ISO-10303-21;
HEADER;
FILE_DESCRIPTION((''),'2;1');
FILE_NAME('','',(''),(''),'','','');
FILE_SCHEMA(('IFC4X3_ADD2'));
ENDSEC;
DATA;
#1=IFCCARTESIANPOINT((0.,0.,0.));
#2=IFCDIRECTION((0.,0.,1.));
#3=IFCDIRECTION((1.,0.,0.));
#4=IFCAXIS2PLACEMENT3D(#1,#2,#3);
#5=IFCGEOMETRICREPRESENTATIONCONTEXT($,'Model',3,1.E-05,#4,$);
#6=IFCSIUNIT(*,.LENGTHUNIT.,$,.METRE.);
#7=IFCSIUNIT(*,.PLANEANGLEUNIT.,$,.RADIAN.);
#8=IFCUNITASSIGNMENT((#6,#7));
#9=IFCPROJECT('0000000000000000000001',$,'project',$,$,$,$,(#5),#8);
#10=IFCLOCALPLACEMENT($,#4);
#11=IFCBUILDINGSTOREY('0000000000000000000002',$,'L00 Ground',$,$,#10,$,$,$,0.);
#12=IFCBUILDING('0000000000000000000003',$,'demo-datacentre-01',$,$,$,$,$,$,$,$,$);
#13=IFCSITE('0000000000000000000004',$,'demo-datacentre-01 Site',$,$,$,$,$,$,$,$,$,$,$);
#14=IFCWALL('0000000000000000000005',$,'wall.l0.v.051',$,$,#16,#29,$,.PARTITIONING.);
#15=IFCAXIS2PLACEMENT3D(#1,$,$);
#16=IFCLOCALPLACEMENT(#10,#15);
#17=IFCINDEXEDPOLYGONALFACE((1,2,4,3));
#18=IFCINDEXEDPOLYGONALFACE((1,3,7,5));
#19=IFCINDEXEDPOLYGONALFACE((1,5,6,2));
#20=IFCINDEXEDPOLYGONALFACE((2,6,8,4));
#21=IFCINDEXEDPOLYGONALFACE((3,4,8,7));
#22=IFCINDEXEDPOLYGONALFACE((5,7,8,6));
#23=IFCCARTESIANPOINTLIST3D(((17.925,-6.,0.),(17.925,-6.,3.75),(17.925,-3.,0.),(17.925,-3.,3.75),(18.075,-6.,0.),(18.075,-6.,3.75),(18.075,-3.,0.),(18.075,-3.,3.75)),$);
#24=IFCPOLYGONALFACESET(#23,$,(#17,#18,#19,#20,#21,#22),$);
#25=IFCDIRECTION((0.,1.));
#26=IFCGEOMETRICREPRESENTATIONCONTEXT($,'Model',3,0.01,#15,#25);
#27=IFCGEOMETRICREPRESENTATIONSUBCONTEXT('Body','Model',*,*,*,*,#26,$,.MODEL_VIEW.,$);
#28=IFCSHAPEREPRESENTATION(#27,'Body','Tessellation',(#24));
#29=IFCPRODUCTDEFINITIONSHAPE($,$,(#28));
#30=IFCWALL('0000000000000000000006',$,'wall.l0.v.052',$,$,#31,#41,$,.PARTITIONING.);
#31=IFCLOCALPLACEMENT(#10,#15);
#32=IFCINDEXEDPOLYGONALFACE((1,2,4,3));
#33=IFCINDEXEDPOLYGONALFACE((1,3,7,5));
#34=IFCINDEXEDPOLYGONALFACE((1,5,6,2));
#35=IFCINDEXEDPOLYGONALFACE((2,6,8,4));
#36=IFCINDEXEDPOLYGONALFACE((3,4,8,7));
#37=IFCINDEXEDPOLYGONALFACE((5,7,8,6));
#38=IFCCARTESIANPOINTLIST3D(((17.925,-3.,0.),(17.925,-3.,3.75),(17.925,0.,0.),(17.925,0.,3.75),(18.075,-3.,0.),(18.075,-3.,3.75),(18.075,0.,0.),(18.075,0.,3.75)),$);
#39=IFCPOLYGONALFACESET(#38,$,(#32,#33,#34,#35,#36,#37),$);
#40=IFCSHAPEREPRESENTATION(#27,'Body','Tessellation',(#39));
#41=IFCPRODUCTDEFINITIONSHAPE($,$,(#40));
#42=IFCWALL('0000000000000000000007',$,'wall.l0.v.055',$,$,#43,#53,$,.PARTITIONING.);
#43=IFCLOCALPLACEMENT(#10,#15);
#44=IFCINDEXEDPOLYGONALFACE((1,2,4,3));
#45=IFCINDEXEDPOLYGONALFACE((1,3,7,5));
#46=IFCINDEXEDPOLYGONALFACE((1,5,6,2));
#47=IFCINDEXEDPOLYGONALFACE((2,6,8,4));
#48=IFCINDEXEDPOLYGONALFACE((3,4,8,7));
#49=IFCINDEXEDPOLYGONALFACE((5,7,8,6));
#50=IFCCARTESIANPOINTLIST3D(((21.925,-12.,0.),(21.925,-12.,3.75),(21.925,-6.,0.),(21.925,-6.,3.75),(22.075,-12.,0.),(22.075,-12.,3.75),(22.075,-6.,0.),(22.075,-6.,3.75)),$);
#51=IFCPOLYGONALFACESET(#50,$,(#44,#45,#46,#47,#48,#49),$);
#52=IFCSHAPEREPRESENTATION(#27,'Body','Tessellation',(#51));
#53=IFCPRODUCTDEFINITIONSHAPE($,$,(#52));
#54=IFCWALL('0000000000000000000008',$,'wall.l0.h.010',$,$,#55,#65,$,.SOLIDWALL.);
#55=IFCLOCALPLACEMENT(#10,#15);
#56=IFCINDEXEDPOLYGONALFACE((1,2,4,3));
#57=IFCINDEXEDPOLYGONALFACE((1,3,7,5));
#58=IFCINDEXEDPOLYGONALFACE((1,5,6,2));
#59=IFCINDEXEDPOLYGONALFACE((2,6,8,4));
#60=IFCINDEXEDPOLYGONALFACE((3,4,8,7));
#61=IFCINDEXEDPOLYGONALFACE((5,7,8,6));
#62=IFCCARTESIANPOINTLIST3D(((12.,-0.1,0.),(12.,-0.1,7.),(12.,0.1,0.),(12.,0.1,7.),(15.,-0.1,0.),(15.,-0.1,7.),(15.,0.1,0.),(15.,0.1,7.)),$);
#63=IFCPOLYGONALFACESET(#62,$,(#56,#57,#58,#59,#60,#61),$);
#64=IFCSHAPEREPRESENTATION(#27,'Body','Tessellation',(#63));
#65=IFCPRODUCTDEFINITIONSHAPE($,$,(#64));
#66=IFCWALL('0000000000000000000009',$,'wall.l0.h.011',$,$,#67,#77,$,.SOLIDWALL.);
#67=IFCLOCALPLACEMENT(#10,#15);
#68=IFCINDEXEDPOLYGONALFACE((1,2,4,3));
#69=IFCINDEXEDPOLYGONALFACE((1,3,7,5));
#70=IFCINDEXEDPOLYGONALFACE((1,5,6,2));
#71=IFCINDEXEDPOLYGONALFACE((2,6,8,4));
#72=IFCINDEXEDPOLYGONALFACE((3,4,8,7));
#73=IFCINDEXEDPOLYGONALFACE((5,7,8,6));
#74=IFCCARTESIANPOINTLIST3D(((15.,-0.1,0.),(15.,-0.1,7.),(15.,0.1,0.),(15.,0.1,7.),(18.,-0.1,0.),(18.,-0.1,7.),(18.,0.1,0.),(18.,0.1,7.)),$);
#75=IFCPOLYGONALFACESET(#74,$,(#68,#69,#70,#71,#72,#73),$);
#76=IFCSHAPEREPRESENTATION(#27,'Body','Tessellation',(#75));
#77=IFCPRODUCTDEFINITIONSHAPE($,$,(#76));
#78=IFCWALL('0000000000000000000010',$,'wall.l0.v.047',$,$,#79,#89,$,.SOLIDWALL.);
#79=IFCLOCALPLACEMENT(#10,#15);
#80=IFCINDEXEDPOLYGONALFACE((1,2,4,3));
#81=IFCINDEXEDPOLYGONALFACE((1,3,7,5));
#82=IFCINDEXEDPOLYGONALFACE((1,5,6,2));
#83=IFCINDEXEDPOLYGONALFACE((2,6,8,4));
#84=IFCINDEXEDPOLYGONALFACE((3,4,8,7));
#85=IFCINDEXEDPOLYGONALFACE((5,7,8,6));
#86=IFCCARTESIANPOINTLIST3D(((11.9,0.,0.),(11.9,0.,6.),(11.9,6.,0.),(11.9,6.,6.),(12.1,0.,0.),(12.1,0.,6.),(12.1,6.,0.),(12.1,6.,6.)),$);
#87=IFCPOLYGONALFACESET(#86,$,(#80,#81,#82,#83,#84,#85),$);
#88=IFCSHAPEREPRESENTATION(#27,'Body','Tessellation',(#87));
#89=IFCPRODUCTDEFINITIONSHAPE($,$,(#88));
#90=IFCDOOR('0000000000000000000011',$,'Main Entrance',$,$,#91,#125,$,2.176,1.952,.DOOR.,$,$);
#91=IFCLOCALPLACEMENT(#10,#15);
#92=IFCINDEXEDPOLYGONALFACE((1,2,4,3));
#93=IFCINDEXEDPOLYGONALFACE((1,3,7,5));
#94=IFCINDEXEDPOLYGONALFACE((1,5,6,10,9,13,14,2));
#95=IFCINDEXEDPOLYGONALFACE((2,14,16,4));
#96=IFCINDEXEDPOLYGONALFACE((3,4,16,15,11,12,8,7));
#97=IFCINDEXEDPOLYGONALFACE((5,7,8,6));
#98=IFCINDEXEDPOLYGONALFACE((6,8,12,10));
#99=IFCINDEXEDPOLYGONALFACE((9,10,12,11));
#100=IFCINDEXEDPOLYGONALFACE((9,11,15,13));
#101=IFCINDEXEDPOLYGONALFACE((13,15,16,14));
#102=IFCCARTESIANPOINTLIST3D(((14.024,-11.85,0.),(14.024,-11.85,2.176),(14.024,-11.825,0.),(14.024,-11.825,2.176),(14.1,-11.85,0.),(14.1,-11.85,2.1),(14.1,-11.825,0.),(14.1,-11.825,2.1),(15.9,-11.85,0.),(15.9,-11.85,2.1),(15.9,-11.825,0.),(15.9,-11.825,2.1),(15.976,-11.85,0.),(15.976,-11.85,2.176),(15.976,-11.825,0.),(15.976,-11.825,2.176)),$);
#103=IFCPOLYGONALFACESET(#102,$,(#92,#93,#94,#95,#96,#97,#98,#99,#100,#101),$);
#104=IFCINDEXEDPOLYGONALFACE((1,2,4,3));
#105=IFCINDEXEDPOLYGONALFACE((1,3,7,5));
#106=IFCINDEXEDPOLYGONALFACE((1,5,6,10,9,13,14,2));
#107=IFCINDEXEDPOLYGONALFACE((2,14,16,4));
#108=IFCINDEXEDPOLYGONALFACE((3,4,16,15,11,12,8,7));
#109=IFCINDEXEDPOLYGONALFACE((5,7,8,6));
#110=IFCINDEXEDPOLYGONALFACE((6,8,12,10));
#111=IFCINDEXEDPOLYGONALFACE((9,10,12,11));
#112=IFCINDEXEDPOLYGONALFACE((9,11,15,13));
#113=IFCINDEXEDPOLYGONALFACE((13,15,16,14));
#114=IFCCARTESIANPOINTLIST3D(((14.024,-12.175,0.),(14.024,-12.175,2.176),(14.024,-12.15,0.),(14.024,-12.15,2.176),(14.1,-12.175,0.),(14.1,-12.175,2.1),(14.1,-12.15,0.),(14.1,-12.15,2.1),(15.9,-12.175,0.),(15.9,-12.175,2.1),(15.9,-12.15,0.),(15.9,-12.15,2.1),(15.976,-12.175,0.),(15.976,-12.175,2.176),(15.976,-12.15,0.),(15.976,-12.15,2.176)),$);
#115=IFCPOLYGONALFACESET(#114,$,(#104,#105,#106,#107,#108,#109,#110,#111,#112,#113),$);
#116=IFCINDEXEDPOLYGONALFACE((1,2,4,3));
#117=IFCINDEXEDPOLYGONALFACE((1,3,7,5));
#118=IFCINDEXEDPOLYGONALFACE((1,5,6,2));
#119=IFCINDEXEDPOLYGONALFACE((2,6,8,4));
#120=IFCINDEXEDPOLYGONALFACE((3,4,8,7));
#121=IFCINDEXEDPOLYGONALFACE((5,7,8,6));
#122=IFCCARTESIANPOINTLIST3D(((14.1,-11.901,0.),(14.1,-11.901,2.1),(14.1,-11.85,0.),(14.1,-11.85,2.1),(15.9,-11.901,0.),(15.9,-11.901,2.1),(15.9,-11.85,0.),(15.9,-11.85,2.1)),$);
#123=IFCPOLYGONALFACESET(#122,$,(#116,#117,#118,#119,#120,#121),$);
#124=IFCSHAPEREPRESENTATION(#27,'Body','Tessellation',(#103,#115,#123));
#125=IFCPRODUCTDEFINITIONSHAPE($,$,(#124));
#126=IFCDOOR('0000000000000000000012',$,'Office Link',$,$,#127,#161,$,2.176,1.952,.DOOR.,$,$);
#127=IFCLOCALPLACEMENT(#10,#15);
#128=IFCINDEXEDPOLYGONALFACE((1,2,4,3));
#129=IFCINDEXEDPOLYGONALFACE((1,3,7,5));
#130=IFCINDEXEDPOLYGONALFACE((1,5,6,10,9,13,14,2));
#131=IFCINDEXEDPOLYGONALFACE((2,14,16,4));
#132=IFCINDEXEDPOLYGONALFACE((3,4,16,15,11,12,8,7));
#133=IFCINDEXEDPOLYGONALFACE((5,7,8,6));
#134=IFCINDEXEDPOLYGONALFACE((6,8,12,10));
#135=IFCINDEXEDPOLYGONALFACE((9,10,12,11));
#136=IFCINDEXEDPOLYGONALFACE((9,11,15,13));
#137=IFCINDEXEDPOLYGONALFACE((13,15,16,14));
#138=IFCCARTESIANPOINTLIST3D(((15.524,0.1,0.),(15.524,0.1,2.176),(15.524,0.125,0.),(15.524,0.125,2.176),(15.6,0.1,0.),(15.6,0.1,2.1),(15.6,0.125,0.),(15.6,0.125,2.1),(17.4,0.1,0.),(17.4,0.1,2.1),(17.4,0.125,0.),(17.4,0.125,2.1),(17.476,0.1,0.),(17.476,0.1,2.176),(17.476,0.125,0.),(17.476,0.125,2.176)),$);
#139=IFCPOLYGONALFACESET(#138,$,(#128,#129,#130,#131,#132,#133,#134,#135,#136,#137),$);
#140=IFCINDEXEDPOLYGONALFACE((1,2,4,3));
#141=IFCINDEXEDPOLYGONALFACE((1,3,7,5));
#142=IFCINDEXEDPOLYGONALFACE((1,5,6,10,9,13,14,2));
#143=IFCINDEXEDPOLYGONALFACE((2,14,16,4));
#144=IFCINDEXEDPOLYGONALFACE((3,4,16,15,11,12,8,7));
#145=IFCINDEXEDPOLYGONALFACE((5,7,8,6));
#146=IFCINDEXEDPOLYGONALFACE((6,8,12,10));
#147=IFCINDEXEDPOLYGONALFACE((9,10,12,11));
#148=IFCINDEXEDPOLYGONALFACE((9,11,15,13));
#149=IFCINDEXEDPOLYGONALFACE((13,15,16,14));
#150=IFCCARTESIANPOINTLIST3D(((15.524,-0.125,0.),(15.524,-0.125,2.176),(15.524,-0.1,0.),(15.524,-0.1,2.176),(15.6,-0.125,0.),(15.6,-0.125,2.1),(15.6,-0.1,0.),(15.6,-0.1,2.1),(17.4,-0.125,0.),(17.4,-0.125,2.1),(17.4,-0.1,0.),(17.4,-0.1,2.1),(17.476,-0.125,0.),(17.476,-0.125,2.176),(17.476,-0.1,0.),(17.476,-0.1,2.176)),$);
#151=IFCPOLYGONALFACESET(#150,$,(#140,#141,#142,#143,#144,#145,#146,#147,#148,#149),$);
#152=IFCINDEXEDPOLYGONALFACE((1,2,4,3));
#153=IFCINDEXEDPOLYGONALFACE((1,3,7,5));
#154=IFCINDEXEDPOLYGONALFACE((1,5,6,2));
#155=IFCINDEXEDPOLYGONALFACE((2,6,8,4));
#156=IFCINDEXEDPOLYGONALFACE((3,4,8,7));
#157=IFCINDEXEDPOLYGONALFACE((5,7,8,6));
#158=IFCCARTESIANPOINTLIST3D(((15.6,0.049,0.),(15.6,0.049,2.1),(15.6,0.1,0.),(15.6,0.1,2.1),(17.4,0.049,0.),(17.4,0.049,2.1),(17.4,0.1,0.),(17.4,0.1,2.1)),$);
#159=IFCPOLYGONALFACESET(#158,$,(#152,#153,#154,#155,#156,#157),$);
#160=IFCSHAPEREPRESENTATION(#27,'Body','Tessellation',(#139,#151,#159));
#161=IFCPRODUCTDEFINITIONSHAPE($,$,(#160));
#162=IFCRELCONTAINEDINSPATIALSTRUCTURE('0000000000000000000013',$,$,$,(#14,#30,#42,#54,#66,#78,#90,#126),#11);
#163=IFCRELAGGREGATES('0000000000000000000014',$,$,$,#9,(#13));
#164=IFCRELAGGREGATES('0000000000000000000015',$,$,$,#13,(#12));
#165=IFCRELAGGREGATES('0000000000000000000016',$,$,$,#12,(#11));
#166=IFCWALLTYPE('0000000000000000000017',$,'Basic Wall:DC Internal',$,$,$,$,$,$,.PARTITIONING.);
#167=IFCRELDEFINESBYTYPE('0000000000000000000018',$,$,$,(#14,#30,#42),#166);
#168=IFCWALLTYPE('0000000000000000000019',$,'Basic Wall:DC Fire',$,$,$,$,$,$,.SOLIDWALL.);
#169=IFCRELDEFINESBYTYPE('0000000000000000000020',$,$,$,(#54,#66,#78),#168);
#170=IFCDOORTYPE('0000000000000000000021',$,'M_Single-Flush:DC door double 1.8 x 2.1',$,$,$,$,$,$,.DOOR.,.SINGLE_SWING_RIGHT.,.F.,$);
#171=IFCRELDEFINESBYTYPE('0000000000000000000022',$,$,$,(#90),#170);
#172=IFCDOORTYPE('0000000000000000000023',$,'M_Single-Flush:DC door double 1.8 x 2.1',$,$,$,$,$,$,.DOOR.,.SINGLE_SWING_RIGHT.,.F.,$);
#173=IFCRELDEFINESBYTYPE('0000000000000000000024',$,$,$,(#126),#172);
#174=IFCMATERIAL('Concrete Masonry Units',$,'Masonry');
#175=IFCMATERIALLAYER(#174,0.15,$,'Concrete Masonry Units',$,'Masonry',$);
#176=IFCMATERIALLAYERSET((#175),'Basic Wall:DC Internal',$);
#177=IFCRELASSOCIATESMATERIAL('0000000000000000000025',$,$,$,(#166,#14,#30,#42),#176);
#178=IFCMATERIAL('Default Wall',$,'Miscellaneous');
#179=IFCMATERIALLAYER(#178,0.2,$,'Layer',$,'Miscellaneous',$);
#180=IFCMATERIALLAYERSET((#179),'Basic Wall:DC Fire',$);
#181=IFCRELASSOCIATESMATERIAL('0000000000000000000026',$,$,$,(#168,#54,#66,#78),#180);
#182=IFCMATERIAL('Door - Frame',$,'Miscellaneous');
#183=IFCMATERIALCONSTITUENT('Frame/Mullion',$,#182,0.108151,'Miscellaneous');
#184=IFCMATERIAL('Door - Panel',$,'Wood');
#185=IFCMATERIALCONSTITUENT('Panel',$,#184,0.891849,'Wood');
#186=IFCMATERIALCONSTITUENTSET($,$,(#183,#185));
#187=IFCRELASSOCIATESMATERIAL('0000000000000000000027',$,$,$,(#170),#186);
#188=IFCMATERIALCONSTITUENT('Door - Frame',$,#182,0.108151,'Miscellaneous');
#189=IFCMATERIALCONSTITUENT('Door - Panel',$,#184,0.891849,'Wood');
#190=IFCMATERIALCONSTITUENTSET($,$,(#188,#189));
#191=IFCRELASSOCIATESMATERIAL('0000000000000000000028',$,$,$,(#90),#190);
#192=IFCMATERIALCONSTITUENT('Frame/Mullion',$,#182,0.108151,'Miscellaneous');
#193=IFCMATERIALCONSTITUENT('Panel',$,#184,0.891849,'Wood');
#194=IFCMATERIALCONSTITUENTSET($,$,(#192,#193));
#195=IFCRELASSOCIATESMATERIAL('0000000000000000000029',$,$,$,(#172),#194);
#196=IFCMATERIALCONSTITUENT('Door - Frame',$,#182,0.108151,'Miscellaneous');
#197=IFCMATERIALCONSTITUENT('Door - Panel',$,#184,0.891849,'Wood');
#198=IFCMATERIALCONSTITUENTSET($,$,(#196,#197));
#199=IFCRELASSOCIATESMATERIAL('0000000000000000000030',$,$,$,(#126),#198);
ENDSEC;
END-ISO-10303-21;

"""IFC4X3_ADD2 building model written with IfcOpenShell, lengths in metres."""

from ifc_helpers import new_model, si_unit, direction, frame, frame_2d, origin, origin_with_axes, place, context, subcontext, project, spatial, polyline, rectangle, outline, extrude, source, transform, mapped, material, layer, layer_set, constituent, constituent_set, type_object, type_shapes, element, save


model = new_model("IFC4X3_ADD2")

# Units and contexts
model_context_1 = context("Model", 3, precision=0.01, world=origin(), true_north=direction((0.0, 1.0)))
model_context_2 = context("Model", 3, precision=1e-05, world=origin_with_axes())
body_context = subcontext(model_context_1, "Body", "Model", "MODEL_VIEW")
ifc_project = project(units=[si_unit("LENGTHUNIT", "METRE"), si_unit("PLANEANGLEUNIT", "RADIAN")], contexts=[model_context_2])

# Site, building, storey
site = spatial("IfcSite", under=ifc_project, Name="demo-datacentre-01 Site")
building = spatial("IfcBuilding", under=site, Name="demo-datacentre-01")
storey_placement = place(None, origin_with_axes())
storey = spatial("IfcBuildingStorey", under=building, at=storey_placement, Name="L00 Ground", Elevation=0.0)

# Shared definitions
placement_1 = place(None, origin())
placement_2 = place(placement_1, origin())
placement_3 = place(placement_2, origin())

# Walls
ifc_material_1 = material(Name="Default Wall", Category="Miscellaneous")
ifc_material_2 = material(Name="Concrete Masonry Units", Category="Masonry")
ifc_layer_1 = layer(ifc_material_2, 0.15, Name="Concrete Masonry Units", Category="Masonry")
ifc_layer_set_1 = layer_set([ifc_layer_1], Name="Basic Wall:DC Internal")
wall_type_1 = type_object("IfcWallType", Name="Basic Wall:DC Internal", PredefinedType="PARTITIONING", material=ifc_layer_set_1)
for number, where, z_axis, x_axis, name in (
    (1, (18.0, -6.0, 0.0), (0.0, 0.0, 1.0), (0.0, 1.0, 0.0), "wall.l0.v.051"),
    (2, (18.0, -3.0, 0.0), (0.0, 0.0, 1.0), (0.0, 1.0, 0.0), "wall.l0.v.052"),
):
    element("IfcWall", number, at=place(placement_3, frame(where, z_axis=z_axis, x_axis=x_axis)), inside=storey, type_object=wall_type_1, material=ifc_layer_set_1, Name=name, PredefinedType="PARTITIONING", context=body_context, shape_type="SweptSolid", body=[
        extrude(rectangle(XDim=3.0, YDim=0.15, at=frame_2d((1.5, 0.0), x_axis=(-1.0, 0.0))), origin(), (0.0, 0.0, 1.0), 3.75),
    ])
wall_1_placement = place(placement_3, frame((22.0, -12.0, 0.0), z_axis=(0.0, 0.0, 1.0), x_axis=(0.0, 1.0, 0.0)))
element("IfcWall", 3, at=wall_1_placement, inside=storey, type_object=wall_type_1, material=ifc_layer_set_1, Name="wall.l0.v.055", PredefinedType="PARTITIONING", context=body_context, shape_type="SweptSolid", body=[
    extrude(rectangle(XDim=6.0, YDim=0.15, at=frame_2d((3.0, 0.0), x_axis=(-1.0, 0.0))), origin(), (0.0, 0.0, 1.0), 3.75),
])
ifc_layer_2 = layer(ifc_material_1, 0.2, Name="Layer", Category="Miscellaneous")
ifc_layer_set_2 = layer_set([ifc_layer_2], Name="Basic Wall:DC Fire")
wall_type_2 = type_object("IfcWallType", Name="Basic Wall:DC Fire", PredefinedType="SOLIDWALL", material=ifc_layer_set_2)
for number, where, name in (
    (4, (12.0, 0.0, 0.0), "wall.l0.h.010"),
    (5, (15.0, 0.0, 0.0), "wall.l0.h.011"),
):
    element("IfcWall", number, at=place(placement_3, frame(where)), inside=storey, type_object=wall_type_2, material=ifc_layer_set_2, Name=name, PredefinedType="SOLIDWALL", context=body_context, shape_type="SweptSolid", body=[
        extrude(rectangle(XDim=3.0, YDim=0.2, at=frame_2d((1.5, 0.0), x_axis=(-1.0, 0.0))), origin(), (0.0, 0.0, 1.0), 7.0),
    ])
wall_2_placement = place(placement_3, frame((12.0, 0.0, 0.0), z_axis=(0.0, 0.0, 1.0), x_axis=(0.0, 1.0, 0.0)))
element("IfcWall", 6, at=wall_2_placement, inside=storey, type_object=wall_type_2, material=ifc_layer_set_2, Name="wall.l0.v.047", PredefinedType="SOLIDWALL", context=body_context, shape_type="SweptSolid", body=[
    extrude(rectangle(XDim=6.0, YDim=0.2, at=frame_2d((3.0, 0.0), x_axis=(-1.0, 0.0))), origin(), (0.0, 0.0, 1.0), 6.0),
])

# Doors
ifc_material_3 = material(Name="Door - Frame", Category="Miscellaneous")
ifc_constituent_1 = constituent(ifc_material_3, Name="Door - Frame", Category="Miscellaneous", fraction=0.108151)
ifc_material_4 = material(Name="Door - Panel", Category="Wood")
ifc_constituent_2 = constituent(ifc_material_4, Name="Door - Panel", Category="Wood", fraction=0.891849)
ifc_constituent_set_1 = constituent_set(constituents=[ifc_constituent_1, ifc_constituent_2])
ifc_constituent_3 = constituent(ifc_material_3, Name="Frame/Mullion", Category="Miscellaneous", fraction=0.108151)
ifc_constituent_4 = constituent(ifc_material_4, Name="Panel", Category="Wood", fraction=0.891849)
ifc_constituent_set_2 = constituent_set(constituents=[ifc_constituent_3, ifc_constituent_4])
door_type_1 = type_object("IfcDoorType", Name="M_Single-Flush:DC door double 1.8 x 2.1", OperationType="SINGLE_SWING_RIGHT", ParameterTakesPrecedence=False, PredefinedType="DOOR", material=ifc_constituent_set_2)
shared_shape_1 = source(origin(), body_context, "Body", "SweptSolid", [
    extrude(outline(polyline([(-0.976, -1.107), (0.976, -1.107), (0.976, 1.069), (0.9, 1.069), (0.9, -1.031), (-0.9, -1.031), (-0.9, 1.069), (-0.976, 1.069), (-0.976, -1.107)])), frame((0.9, 0.3, 1.069), z_axis=(0.0, 1.0, 0.0), x_axis=(1.0, 0.0, 0.0)), (0.0, 0.0, 1.0), 0.025),
    extrude(outline(polyline([(-1.107, -0.976), (1.069, -0.976), (1.069, -0.9), (-1.031, -0.9), (-1.031, 0.9), (1.069, 0.9), (1.069, 0.976), (-1.107, 0.976), (-1.107, -0.976)])), frame((0.9, -0.025, 1.069), z_axis=(0.0, 1.0, 0.0), x_axis=(0.0, 0.0, -1.0)), (0.0, 0.0, 1.0), 0.025),
    extrude(rectangle(XDim=0.051, YDim=1.8, at=frame_2d((0.0, 0.0), x_axis=(1.0, 0.0))), frame((0.9, 0.2745, 0.0), z_axis=(0.0, 0.0, 1.0), x_axis=(0.0, 1.0, 0.0)), (0.0, 0.0, 1.0), 2.1),
])
type_shapes(door_type_1, [shared_shape_1])
door_1_placement = place(placement_3, frame((14.1, -12.15, 0.0)))
element("IfcDoor", 7, at=door_1_placement, inside=storey, type_object=door_type_1, material=ifc_constituent_set_1, Name="Main Entrance", OverallHeight=2.176, OverallWidth=1.952, PredefinedType="DOOR", context=body_context, shape_type="MappedRepresentation", body=[
    mapped(shared_shape_1, transform((0.0, 0.0, 0.0), scale=1.0)),
])
ifc_constituent_5 = constituent(ifc_material_3, Name="Door - Frame", Category="Miscellaneous", fraction=0.108151)
ifc_constituent_6 = constituent(ifc_material_4, Name="Door - Panel", Category="Wood", fraction=0.891849)
ifc_constituent_set_3 = constituent_set(constituents=[ifc_constituent_5, ifc_constituent_6])
ifc_constituent_7 = constituent(ifc_material_3, Name="Frame/Mullion", Category="Miscellaneous", fraction=0.108151)
ifc_constituent_8 = constituent(ifc_material_4, Name="Panel", Category="Wood", fraction=0.891849)
ifc_constituent_set_4 = constituent_set(constituents=[ifc_constituent_7, ifc_constituent_8])
door_type_2 = type_object("IfcDoorType", Name="M_Single-Flush:DC door double 1.8 x 2.1", OperationType="SINGLE_SWING_RIGHT", ParameterTakesPrecedence=False, PredefinedType="DOOR", material=ifc_constituent_set_4)
shared_shape_2 = source(origin(), body_context, "Body", "SweptSolid", [
    extrude(outline(polyline([(-0.976, -1.107), (0.976, -1.107), (0.976, 1.069), (0.9, 1.069), (0.9, -1.031), (-0.9, -1.031), (-0.9, 1.069), (-0.976, 1.069), (-0.976, -1.107)])), frame((0.9, 0.2, 1.069), z_axis=(0.0, 1.0, 0.0), x_axis=(1.0, 0.0, 0.0)), (0.0, 0.0, 1.0), 0.025),
    extrude(outline(polyline([(-1.107, -0.976), (1.069, -0.976), (1.069, -0.9), (-1.031, -0.9), (-1.031, 0.9), (1.069, 0.9), (1.069, 0.976), (-1.107, 0.976), (-1.107, -0.976)])), frame((0.9, -0.025, 1.069), z_axis=(0.0, 1.0, 0.0), x_axis=(0.0, 0.0, -1.0)), (0.0, 0.0, 1.0), 0.025),
    extrude(rectangle(XDim=0.051, YDim=1.8, at=frame_2d((0.0, 0.0), x_axis=(1.0, 0.0))), frame((0.9, 0.1745, 0.0), z_axis=(0.0, 0.0, 1.0), x_axis=(0.0, 1.0, 0.0)), (0.0, 0.0, 1.0), 2.1),
])
type_shapes(door_type_2, [shared_shape_2])
door_2_placement = place(placement_3, frame((15.6, -0.1, 0.0)))
element("IfcDoor", 8, at=door_2_placement, inside=storey, type_object=door_type_2, material=ifc_constituent_set_3, Name="Office Link", OverallHeight=2.176, OverallWidth=1.952, PredefinedType="DOOR", context=body_context, shape_type="MappedRepresentation", body=[
    mapped(shared_shape_2, transform((0.0, 0.0, 0.0), scale=1.0)),
])

save(model, "model.ifc")
